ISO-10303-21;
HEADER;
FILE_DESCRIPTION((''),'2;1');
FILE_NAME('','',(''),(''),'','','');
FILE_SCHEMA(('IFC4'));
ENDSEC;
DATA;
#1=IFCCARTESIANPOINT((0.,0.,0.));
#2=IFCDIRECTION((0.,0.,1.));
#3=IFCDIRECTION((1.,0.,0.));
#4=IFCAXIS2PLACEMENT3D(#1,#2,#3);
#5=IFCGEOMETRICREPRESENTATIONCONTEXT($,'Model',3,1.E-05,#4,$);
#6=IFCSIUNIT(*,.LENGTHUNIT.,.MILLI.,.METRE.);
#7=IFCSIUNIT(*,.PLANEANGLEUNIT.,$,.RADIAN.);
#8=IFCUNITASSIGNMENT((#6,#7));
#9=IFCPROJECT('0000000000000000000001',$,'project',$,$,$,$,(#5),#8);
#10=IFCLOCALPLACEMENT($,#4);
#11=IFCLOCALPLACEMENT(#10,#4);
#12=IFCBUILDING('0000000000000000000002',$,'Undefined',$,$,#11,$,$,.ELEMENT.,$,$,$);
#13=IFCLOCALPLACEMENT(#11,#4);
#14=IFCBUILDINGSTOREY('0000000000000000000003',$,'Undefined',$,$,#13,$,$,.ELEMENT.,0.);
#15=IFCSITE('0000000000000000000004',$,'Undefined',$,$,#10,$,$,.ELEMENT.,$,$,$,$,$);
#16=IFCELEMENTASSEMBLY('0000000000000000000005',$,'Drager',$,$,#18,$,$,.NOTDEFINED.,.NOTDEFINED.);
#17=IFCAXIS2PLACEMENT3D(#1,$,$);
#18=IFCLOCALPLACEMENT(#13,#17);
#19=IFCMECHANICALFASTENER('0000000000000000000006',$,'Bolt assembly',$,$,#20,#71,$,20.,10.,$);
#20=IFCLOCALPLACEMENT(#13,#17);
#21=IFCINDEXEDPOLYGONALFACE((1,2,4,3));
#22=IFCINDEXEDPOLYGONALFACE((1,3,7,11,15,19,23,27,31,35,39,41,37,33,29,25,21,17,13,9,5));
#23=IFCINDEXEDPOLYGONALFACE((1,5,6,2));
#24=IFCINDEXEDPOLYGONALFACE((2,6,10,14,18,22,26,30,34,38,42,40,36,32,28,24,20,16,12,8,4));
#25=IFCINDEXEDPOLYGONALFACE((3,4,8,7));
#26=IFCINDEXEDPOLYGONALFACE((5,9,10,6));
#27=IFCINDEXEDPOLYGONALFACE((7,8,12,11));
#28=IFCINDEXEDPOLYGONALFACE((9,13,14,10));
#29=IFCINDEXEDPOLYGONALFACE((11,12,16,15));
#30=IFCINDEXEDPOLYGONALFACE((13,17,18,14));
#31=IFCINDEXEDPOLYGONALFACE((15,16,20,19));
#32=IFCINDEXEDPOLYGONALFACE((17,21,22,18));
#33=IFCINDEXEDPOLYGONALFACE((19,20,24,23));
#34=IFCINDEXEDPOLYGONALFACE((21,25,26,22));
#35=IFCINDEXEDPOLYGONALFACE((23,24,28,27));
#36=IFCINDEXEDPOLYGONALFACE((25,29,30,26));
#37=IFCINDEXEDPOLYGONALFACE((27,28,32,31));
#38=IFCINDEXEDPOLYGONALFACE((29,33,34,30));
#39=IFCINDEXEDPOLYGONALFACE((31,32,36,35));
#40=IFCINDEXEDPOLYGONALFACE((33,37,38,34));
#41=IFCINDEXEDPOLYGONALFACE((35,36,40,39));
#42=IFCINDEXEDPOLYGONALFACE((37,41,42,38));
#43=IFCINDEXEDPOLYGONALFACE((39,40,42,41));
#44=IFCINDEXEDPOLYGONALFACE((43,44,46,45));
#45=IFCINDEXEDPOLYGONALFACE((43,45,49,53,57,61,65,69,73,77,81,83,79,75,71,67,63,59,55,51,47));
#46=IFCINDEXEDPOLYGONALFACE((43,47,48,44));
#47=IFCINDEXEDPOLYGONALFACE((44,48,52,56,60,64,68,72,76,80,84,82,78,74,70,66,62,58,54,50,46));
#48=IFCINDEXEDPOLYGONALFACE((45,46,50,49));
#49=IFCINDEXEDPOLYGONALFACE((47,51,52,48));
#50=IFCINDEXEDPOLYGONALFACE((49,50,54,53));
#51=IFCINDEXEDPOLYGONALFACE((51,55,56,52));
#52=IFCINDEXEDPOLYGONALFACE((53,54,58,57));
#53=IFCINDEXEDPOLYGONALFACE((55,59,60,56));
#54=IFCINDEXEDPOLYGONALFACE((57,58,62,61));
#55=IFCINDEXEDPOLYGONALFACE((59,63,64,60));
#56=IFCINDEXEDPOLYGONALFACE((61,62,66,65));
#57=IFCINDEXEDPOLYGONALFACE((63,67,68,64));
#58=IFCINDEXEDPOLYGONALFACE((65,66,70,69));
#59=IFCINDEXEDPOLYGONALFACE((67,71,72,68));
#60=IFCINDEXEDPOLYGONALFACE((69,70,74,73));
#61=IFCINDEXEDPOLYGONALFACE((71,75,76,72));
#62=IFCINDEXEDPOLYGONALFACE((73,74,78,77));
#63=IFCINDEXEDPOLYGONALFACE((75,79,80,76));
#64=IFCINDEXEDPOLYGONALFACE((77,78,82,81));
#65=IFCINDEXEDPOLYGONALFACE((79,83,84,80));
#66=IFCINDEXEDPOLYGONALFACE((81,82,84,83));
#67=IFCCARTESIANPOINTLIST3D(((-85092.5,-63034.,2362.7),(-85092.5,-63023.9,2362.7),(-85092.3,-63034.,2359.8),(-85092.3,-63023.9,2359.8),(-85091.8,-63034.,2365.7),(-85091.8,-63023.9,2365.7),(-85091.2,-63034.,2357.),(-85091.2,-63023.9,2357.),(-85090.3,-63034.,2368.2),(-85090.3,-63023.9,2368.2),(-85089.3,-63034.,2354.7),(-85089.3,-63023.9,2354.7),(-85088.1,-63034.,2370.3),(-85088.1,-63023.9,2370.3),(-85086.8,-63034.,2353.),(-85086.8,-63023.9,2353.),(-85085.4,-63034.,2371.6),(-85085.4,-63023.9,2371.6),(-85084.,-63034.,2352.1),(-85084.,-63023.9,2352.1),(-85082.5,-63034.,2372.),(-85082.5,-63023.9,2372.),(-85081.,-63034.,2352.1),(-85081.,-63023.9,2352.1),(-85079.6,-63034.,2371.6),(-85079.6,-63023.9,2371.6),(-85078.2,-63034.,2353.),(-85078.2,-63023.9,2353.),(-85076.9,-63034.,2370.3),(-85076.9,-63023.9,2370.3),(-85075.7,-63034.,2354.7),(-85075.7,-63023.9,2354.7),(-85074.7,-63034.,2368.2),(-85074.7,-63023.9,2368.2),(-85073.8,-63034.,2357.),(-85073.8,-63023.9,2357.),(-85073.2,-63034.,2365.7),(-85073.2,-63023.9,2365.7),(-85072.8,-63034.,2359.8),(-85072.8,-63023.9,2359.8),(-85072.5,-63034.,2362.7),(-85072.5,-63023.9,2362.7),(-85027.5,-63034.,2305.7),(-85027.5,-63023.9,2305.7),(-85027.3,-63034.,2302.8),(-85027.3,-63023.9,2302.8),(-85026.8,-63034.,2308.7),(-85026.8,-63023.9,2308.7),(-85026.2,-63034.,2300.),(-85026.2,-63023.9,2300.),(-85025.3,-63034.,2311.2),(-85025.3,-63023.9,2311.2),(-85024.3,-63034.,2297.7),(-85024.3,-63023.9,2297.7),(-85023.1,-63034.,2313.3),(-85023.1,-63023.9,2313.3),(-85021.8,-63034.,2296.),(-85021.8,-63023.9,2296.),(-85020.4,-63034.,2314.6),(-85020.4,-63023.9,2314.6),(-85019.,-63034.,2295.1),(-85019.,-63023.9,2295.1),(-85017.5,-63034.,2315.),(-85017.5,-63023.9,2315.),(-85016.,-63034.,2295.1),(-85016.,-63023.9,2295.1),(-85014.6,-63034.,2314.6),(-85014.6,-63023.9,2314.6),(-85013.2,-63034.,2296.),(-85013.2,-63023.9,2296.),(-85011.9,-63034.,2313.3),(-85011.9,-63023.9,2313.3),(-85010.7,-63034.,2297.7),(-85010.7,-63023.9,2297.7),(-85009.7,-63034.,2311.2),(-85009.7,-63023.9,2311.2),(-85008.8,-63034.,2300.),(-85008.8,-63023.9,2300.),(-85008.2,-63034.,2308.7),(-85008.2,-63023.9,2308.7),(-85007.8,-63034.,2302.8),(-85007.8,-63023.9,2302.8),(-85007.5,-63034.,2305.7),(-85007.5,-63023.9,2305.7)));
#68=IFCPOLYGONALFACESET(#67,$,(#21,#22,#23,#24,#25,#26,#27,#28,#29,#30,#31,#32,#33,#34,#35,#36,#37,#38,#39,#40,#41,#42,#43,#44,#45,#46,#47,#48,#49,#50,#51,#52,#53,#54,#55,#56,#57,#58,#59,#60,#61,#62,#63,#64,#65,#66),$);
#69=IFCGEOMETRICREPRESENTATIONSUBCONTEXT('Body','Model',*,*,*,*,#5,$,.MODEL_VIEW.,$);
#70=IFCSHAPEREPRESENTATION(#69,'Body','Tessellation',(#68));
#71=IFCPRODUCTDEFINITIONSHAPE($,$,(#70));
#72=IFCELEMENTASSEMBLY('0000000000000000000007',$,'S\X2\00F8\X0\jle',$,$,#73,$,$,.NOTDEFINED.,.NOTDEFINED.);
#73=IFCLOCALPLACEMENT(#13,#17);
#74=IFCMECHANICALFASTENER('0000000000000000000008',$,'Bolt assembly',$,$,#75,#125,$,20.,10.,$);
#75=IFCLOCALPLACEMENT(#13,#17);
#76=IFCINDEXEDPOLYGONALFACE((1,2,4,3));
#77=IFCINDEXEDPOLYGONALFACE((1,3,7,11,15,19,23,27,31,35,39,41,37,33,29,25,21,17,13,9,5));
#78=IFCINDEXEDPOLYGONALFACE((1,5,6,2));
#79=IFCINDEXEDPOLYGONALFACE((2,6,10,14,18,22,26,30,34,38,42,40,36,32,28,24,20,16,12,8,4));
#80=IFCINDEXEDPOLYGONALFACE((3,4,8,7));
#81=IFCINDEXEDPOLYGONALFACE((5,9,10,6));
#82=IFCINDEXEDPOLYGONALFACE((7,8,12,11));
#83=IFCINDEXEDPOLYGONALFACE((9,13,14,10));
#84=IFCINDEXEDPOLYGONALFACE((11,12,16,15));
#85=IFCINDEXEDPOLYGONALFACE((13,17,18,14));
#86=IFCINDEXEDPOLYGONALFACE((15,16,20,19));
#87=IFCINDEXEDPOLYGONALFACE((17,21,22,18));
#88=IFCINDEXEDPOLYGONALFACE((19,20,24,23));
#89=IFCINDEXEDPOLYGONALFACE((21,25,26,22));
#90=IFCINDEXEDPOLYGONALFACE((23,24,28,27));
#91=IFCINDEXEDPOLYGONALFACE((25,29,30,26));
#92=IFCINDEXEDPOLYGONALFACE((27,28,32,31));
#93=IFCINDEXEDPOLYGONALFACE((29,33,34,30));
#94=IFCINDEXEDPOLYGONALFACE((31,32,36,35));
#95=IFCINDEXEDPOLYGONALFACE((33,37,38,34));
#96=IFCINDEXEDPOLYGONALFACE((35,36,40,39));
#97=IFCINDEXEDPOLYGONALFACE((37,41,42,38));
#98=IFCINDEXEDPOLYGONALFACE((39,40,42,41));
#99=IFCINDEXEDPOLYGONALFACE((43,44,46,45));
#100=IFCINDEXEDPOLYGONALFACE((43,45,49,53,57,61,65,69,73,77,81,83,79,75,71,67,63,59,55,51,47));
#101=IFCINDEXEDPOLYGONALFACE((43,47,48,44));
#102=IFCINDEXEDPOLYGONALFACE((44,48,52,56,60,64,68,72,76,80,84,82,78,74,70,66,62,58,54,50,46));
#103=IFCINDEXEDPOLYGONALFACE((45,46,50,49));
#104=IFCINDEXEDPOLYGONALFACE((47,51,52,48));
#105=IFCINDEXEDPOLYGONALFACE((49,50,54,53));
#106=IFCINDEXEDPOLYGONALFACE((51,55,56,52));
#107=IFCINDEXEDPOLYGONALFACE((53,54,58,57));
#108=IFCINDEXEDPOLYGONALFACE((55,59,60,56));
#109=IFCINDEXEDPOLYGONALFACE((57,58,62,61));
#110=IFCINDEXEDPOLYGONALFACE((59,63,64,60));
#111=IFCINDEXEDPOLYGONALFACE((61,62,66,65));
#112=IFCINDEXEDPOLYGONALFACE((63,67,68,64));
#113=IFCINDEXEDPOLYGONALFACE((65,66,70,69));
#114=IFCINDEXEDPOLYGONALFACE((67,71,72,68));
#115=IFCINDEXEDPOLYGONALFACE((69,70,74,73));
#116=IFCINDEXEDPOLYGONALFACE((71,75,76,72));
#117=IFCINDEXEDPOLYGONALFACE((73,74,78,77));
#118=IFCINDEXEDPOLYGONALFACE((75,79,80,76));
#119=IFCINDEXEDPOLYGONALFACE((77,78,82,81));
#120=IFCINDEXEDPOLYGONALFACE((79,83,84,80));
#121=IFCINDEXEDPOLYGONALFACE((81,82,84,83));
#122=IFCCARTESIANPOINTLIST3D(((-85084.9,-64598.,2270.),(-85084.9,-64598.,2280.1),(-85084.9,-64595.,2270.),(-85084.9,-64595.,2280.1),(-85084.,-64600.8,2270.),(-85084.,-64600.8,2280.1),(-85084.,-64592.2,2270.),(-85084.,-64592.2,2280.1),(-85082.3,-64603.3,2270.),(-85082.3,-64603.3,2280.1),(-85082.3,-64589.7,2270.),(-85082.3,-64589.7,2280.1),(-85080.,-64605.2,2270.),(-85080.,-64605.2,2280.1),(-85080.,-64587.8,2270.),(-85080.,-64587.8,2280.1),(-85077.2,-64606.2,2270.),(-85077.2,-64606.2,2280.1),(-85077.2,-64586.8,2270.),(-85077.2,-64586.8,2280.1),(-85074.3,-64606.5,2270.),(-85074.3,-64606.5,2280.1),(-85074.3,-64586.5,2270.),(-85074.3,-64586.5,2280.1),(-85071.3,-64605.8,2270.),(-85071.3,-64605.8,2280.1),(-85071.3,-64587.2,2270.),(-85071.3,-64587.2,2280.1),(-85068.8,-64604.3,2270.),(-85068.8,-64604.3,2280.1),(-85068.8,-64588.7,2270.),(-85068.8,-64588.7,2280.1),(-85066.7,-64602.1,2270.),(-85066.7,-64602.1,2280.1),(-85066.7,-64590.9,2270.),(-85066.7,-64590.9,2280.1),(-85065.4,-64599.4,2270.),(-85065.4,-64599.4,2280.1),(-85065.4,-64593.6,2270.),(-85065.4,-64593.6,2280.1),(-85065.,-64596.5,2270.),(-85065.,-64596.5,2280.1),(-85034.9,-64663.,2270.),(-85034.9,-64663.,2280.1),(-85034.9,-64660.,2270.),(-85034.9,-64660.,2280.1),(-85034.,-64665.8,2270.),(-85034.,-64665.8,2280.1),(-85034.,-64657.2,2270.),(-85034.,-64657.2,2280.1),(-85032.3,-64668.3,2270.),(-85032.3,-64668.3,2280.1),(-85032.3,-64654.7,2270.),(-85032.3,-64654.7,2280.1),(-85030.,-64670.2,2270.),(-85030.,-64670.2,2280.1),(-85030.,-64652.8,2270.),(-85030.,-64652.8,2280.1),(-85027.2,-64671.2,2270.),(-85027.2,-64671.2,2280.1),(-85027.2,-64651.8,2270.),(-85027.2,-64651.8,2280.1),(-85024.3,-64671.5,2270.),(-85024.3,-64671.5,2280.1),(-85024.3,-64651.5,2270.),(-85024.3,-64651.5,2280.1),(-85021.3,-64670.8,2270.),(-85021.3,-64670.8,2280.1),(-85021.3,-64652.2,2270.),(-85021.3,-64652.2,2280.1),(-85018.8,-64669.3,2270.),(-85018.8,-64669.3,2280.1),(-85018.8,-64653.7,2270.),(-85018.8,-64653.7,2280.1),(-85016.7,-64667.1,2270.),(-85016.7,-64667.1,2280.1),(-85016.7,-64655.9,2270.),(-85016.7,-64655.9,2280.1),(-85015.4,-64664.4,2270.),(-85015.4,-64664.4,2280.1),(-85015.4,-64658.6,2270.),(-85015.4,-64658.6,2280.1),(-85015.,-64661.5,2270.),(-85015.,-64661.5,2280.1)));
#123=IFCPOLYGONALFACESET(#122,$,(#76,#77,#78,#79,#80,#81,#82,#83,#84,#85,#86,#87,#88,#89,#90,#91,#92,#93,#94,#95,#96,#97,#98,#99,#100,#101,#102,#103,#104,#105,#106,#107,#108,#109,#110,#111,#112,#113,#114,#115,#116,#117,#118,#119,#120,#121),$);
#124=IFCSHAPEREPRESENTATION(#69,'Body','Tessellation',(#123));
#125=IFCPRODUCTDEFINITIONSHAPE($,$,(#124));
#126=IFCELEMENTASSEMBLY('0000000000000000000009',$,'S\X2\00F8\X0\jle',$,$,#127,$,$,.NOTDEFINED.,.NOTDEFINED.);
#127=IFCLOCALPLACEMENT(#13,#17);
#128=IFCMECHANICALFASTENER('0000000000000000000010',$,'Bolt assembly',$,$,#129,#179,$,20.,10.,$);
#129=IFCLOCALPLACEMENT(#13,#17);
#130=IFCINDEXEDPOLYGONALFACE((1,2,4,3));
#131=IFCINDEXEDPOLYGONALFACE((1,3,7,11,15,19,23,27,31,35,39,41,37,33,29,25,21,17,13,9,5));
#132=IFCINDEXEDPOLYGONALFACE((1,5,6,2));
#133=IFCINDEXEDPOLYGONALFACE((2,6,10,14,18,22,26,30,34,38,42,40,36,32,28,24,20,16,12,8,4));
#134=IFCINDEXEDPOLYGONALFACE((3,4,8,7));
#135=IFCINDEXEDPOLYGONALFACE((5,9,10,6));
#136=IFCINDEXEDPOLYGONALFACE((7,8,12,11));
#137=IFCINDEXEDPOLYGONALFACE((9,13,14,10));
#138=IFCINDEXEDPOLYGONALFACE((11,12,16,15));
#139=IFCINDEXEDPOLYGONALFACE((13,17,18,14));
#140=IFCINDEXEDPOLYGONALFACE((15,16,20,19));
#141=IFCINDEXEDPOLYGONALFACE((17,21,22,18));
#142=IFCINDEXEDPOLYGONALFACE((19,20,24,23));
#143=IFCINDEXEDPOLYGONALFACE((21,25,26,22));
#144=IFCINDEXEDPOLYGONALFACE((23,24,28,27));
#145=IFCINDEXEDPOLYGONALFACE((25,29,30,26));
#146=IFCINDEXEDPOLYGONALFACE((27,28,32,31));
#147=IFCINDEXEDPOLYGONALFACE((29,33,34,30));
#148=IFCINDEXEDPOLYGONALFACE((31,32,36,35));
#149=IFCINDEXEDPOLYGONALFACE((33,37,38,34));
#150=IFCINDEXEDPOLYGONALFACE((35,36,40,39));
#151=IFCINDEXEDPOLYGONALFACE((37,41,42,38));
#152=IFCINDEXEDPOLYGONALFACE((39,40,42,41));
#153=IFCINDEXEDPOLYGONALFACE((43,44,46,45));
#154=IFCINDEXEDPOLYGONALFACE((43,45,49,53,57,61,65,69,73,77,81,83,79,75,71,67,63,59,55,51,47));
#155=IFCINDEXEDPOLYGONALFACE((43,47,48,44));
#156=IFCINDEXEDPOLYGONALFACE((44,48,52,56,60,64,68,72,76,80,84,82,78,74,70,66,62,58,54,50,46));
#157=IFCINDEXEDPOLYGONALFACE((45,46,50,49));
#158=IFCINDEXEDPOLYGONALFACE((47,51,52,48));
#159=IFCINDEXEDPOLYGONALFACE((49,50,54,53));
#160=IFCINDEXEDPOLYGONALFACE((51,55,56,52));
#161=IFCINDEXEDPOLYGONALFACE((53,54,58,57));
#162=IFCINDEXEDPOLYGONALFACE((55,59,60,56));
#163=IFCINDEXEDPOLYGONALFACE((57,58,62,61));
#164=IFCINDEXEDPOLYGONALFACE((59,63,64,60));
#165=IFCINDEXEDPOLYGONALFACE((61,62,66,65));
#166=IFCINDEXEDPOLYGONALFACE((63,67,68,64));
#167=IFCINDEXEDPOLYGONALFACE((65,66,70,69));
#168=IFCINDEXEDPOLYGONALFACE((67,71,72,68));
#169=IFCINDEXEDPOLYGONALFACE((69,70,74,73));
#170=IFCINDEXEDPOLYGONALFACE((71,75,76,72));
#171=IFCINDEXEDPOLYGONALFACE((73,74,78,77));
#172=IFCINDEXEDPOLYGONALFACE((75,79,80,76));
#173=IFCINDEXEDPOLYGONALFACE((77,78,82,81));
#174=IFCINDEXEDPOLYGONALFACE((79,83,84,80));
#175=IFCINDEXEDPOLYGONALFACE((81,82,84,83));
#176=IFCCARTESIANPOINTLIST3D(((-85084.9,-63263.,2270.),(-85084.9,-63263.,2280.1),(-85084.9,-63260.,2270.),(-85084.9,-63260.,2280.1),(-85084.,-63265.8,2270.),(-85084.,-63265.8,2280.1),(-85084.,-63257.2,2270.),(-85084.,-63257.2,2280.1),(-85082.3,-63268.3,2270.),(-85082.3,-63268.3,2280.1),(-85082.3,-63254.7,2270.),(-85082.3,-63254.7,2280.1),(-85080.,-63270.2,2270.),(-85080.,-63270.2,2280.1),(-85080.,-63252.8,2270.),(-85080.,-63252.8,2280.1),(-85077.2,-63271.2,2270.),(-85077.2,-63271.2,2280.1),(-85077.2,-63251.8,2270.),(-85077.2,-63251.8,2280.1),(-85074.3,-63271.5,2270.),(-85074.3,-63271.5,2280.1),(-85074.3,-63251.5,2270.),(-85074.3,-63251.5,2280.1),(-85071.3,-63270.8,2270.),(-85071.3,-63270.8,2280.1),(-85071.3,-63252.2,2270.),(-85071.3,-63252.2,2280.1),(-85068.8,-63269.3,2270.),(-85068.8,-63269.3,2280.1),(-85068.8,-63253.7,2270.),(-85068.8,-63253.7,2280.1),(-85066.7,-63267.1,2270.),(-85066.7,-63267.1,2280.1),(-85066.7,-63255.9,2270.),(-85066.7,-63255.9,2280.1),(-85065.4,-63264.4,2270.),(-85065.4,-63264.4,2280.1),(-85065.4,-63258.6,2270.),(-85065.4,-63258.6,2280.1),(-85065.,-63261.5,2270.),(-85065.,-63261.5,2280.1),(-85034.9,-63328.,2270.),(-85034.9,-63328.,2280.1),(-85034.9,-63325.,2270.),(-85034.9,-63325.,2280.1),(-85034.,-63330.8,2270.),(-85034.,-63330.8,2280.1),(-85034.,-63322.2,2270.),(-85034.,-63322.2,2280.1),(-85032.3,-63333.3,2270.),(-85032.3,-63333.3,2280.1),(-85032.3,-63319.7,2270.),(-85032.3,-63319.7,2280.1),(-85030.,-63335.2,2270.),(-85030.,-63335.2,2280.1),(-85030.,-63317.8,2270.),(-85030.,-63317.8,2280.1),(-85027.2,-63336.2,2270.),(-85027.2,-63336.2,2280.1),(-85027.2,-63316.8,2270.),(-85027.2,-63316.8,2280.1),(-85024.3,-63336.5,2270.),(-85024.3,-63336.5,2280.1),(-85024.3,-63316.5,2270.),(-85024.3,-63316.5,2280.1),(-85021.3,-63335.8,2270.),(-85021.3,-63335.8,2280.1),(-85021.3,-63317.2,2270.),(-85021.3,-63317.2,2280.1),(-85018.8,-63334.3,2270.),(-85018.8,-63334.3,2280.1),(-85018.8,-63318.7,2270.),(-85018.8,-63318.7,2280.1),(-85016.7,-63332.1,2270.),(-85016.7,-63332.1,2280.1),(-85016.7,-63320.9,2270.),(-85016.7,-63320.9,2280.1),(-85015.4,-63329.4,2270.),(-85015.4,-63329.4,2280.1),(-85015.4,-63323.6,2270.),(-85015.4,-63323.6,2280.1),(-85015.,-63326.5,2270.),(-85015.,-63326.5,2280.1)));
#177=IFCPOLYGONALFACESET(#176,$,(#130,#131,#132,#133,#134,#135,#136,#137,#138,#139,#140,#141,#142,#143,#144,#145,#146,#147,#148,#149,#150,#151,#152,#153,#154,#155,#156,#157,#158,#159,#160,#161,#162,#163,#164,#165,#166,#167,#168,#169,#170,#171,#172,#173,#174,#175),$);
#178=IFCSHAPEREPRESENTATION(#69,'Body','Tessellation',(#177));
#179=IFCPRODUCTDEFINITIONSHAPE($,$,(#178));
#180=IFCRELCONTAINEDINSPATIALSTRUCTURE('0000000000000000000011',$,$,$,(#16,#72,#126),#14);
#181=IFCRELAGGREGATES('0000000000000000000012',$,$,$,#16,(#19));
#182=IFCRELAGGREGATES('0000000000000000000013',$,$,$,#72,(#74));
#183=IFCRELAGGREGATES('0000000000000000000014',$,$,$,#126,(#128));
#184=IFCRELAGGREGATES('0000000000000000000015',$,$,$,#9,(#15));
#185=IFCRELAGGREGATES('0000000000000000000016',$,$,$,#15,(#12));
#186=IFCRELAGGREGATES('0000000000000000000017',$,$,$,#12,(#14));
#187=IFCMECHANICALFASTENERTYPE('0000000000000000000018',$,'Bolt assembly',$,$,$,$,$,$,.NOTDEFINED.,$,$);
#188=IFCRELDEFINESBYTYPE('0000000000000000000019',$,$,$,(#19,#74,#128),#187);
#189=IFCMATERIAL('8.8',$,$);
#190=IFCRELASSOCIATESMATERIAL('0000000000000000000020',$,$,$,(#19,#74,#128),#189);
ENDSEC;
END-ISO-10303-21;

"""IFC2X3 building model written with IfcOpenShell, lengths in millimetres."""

from ifc_helpers import new_model, si_unit, frame, origin_with_axes, origin_2d_with_axis, place, context, subcontext, project, spatial, circle, extrude, source, transform, mapped, material, type_object, element, aggregate, save


model = new_model("IFC2X3")

# Units and contexts
model_context = context("Model", 3, precision=1e-05, world=origin_with_axes())
body_context = subcontext(model_context, "Body", "Model", "MODEL_VIEW")
ifc_project = project(units=[si_unit("LENGTHUNIT", "METRE", prefix="MILLI"), si_unit("PLANEANGLEUNIT", "RADIAN")], contexts=[model_context])

# Site, building, storey
site_placement = place(None, origin_with_axes())
site = spatial("IfcSite", under=ifc_project, at=site_placement, Name="Undefined", CompositionType="ELEMENT")
building_placement = place(site_placement, origin_with_axes())
building = spatial("IfcBuilding", under=site, at=building_placement, Name="Undefined", CompositionType="ELEMENT")
storey_placement = place(building_placement, origin_with_axes())
storey = spatial("IfcBuildingStorey", under=building, at=storey_placement, Name="Undefined", CompositionType="ELEMENT", Elevation=0.0)

# Element assembly
assembly_1_placement = place(storey_placement, origin_with_axes())
assembly_1 = element("IfcElementAssembly", 1, at=assembly_1_placement, inside=storey, Name="Drager", AssemblyPlace="NOTDEFINED", PredefinedType="NOTDEFINED")

# Mechanical fastener
ifc_material_1 = material(Name="8.8")
mechanical_fastener_type = type_object("IfcMechanicalFastenerType", Name="Bolt assembly")
shared_shape_1 = source(origin_with_axes(), body_context, "Body", "SweptSolid", [
    extrude(circle(Radius=10.0, at=origin_2d_with_axis()), frame((0.0, 0.0, 0.0), z_axis=(0.0, 1.0, 0.0), x_axis=(1.0, 0.0, 0.0)), (0.0, 0.0, 1.0), 10.1),
])
mechanical_fastener_1_placement = place(assembly_1_placement, frame((-85050.0, -63034.0, 2305.0), z_axis=(-1.0, 0.0, 0.0), x_axis=(0.0, 0.0, 1.0)))
mechanical_fastener_1 = element("IfcMechanicalFastener", 2, at=mechanical_fastener_1_placement, type_object=mechanical_fastener_type, material=ifc_material_1, Name="Bolt assembly", NominalDiameter=20.0, NominalLength=10.0, context=body_context, shape_type="MappedRepresentation", body=[
    mapped(shared_shape_1, transform((0.0, 0.0, -32.5))),
    mapped(shared_shape_1, transform((57.0, 0.0, 32.5))),
])
aggregate(assembly_1, [mechanical_fastener_1])

# Element assemblies, mechanical fasteners
assembly_2_placement = place(storey_placement, origin_with_axes())
assembly_2 = element("IfcElementAssembly", 3, at=assembly_2_placement, inside=storey, Name="Søjle", AssemblyPlace="NOTDEFINED", PredefinedType="NOTDEFINED")
mechanical_fastener_2_placement = place(assembly_2_placement, frame((-85075.0, -64629.0, 2270.0), z_axis=(0.0, -1.0, 0.0), x_axis=(1.0, 0.0, 0.0)))
mechanical_fastener_2 = element("IfcMechanicalFastener", 4, at=mechanical_fastener_2_placement, type_object=mechanical_fastener_type, material=ifc_material_1, Name="Bolt assembly", NominalDiameter=20.0, NominalLength=10.0, context=body_context, shape_type="MappedRepresentation", body=[
    mapped(shared_shape_1, transform((0.0, 0.0, -32.5))),
    mapped(shared_shape_1, transform((50.0, 0.0, 32.5))),
])
assembly_3_placement = place(storey_placement, origin_with_axes())
assembly_3 = element("IfcElementAssembly", 5, at=assembly_3_placement, inside=storey, Name="Søjle", AssemblyPlace="NOTDEFINED", PredefinedType="NOTDEFINED")
mechanical_fastener_3_placement = place(assembly_3_placement, frame((-85075.0, -63294.0, 2270.0), z_axis=(0.0, -1.0, 0.0), x_axis=(1.0, 0.0, 0.0)))
mechanical_fastener_3 = element("IfcMechanicalFastener", 6, at=mechanical_fastener_3_placement, type_object=mechanical_fastener_type, material=ifc_material_1, Name="Bolt assembly", NominalDiameter=20.0, NominalLength=10.0, context=body_context, shape_type="MappedRepresentation", body=[
    mapped(shared_shape_1, transform((0.0, 0.0, -32.5))),
    mapped(shared_shape_1, transform((50.0, 0.0, 32.5))),
])

aggregate(assembly_2, [mechanical_fastener_2])
aggregate(assembly_3, [mechanical_fastener_3])

save(model, "model.ifc")
